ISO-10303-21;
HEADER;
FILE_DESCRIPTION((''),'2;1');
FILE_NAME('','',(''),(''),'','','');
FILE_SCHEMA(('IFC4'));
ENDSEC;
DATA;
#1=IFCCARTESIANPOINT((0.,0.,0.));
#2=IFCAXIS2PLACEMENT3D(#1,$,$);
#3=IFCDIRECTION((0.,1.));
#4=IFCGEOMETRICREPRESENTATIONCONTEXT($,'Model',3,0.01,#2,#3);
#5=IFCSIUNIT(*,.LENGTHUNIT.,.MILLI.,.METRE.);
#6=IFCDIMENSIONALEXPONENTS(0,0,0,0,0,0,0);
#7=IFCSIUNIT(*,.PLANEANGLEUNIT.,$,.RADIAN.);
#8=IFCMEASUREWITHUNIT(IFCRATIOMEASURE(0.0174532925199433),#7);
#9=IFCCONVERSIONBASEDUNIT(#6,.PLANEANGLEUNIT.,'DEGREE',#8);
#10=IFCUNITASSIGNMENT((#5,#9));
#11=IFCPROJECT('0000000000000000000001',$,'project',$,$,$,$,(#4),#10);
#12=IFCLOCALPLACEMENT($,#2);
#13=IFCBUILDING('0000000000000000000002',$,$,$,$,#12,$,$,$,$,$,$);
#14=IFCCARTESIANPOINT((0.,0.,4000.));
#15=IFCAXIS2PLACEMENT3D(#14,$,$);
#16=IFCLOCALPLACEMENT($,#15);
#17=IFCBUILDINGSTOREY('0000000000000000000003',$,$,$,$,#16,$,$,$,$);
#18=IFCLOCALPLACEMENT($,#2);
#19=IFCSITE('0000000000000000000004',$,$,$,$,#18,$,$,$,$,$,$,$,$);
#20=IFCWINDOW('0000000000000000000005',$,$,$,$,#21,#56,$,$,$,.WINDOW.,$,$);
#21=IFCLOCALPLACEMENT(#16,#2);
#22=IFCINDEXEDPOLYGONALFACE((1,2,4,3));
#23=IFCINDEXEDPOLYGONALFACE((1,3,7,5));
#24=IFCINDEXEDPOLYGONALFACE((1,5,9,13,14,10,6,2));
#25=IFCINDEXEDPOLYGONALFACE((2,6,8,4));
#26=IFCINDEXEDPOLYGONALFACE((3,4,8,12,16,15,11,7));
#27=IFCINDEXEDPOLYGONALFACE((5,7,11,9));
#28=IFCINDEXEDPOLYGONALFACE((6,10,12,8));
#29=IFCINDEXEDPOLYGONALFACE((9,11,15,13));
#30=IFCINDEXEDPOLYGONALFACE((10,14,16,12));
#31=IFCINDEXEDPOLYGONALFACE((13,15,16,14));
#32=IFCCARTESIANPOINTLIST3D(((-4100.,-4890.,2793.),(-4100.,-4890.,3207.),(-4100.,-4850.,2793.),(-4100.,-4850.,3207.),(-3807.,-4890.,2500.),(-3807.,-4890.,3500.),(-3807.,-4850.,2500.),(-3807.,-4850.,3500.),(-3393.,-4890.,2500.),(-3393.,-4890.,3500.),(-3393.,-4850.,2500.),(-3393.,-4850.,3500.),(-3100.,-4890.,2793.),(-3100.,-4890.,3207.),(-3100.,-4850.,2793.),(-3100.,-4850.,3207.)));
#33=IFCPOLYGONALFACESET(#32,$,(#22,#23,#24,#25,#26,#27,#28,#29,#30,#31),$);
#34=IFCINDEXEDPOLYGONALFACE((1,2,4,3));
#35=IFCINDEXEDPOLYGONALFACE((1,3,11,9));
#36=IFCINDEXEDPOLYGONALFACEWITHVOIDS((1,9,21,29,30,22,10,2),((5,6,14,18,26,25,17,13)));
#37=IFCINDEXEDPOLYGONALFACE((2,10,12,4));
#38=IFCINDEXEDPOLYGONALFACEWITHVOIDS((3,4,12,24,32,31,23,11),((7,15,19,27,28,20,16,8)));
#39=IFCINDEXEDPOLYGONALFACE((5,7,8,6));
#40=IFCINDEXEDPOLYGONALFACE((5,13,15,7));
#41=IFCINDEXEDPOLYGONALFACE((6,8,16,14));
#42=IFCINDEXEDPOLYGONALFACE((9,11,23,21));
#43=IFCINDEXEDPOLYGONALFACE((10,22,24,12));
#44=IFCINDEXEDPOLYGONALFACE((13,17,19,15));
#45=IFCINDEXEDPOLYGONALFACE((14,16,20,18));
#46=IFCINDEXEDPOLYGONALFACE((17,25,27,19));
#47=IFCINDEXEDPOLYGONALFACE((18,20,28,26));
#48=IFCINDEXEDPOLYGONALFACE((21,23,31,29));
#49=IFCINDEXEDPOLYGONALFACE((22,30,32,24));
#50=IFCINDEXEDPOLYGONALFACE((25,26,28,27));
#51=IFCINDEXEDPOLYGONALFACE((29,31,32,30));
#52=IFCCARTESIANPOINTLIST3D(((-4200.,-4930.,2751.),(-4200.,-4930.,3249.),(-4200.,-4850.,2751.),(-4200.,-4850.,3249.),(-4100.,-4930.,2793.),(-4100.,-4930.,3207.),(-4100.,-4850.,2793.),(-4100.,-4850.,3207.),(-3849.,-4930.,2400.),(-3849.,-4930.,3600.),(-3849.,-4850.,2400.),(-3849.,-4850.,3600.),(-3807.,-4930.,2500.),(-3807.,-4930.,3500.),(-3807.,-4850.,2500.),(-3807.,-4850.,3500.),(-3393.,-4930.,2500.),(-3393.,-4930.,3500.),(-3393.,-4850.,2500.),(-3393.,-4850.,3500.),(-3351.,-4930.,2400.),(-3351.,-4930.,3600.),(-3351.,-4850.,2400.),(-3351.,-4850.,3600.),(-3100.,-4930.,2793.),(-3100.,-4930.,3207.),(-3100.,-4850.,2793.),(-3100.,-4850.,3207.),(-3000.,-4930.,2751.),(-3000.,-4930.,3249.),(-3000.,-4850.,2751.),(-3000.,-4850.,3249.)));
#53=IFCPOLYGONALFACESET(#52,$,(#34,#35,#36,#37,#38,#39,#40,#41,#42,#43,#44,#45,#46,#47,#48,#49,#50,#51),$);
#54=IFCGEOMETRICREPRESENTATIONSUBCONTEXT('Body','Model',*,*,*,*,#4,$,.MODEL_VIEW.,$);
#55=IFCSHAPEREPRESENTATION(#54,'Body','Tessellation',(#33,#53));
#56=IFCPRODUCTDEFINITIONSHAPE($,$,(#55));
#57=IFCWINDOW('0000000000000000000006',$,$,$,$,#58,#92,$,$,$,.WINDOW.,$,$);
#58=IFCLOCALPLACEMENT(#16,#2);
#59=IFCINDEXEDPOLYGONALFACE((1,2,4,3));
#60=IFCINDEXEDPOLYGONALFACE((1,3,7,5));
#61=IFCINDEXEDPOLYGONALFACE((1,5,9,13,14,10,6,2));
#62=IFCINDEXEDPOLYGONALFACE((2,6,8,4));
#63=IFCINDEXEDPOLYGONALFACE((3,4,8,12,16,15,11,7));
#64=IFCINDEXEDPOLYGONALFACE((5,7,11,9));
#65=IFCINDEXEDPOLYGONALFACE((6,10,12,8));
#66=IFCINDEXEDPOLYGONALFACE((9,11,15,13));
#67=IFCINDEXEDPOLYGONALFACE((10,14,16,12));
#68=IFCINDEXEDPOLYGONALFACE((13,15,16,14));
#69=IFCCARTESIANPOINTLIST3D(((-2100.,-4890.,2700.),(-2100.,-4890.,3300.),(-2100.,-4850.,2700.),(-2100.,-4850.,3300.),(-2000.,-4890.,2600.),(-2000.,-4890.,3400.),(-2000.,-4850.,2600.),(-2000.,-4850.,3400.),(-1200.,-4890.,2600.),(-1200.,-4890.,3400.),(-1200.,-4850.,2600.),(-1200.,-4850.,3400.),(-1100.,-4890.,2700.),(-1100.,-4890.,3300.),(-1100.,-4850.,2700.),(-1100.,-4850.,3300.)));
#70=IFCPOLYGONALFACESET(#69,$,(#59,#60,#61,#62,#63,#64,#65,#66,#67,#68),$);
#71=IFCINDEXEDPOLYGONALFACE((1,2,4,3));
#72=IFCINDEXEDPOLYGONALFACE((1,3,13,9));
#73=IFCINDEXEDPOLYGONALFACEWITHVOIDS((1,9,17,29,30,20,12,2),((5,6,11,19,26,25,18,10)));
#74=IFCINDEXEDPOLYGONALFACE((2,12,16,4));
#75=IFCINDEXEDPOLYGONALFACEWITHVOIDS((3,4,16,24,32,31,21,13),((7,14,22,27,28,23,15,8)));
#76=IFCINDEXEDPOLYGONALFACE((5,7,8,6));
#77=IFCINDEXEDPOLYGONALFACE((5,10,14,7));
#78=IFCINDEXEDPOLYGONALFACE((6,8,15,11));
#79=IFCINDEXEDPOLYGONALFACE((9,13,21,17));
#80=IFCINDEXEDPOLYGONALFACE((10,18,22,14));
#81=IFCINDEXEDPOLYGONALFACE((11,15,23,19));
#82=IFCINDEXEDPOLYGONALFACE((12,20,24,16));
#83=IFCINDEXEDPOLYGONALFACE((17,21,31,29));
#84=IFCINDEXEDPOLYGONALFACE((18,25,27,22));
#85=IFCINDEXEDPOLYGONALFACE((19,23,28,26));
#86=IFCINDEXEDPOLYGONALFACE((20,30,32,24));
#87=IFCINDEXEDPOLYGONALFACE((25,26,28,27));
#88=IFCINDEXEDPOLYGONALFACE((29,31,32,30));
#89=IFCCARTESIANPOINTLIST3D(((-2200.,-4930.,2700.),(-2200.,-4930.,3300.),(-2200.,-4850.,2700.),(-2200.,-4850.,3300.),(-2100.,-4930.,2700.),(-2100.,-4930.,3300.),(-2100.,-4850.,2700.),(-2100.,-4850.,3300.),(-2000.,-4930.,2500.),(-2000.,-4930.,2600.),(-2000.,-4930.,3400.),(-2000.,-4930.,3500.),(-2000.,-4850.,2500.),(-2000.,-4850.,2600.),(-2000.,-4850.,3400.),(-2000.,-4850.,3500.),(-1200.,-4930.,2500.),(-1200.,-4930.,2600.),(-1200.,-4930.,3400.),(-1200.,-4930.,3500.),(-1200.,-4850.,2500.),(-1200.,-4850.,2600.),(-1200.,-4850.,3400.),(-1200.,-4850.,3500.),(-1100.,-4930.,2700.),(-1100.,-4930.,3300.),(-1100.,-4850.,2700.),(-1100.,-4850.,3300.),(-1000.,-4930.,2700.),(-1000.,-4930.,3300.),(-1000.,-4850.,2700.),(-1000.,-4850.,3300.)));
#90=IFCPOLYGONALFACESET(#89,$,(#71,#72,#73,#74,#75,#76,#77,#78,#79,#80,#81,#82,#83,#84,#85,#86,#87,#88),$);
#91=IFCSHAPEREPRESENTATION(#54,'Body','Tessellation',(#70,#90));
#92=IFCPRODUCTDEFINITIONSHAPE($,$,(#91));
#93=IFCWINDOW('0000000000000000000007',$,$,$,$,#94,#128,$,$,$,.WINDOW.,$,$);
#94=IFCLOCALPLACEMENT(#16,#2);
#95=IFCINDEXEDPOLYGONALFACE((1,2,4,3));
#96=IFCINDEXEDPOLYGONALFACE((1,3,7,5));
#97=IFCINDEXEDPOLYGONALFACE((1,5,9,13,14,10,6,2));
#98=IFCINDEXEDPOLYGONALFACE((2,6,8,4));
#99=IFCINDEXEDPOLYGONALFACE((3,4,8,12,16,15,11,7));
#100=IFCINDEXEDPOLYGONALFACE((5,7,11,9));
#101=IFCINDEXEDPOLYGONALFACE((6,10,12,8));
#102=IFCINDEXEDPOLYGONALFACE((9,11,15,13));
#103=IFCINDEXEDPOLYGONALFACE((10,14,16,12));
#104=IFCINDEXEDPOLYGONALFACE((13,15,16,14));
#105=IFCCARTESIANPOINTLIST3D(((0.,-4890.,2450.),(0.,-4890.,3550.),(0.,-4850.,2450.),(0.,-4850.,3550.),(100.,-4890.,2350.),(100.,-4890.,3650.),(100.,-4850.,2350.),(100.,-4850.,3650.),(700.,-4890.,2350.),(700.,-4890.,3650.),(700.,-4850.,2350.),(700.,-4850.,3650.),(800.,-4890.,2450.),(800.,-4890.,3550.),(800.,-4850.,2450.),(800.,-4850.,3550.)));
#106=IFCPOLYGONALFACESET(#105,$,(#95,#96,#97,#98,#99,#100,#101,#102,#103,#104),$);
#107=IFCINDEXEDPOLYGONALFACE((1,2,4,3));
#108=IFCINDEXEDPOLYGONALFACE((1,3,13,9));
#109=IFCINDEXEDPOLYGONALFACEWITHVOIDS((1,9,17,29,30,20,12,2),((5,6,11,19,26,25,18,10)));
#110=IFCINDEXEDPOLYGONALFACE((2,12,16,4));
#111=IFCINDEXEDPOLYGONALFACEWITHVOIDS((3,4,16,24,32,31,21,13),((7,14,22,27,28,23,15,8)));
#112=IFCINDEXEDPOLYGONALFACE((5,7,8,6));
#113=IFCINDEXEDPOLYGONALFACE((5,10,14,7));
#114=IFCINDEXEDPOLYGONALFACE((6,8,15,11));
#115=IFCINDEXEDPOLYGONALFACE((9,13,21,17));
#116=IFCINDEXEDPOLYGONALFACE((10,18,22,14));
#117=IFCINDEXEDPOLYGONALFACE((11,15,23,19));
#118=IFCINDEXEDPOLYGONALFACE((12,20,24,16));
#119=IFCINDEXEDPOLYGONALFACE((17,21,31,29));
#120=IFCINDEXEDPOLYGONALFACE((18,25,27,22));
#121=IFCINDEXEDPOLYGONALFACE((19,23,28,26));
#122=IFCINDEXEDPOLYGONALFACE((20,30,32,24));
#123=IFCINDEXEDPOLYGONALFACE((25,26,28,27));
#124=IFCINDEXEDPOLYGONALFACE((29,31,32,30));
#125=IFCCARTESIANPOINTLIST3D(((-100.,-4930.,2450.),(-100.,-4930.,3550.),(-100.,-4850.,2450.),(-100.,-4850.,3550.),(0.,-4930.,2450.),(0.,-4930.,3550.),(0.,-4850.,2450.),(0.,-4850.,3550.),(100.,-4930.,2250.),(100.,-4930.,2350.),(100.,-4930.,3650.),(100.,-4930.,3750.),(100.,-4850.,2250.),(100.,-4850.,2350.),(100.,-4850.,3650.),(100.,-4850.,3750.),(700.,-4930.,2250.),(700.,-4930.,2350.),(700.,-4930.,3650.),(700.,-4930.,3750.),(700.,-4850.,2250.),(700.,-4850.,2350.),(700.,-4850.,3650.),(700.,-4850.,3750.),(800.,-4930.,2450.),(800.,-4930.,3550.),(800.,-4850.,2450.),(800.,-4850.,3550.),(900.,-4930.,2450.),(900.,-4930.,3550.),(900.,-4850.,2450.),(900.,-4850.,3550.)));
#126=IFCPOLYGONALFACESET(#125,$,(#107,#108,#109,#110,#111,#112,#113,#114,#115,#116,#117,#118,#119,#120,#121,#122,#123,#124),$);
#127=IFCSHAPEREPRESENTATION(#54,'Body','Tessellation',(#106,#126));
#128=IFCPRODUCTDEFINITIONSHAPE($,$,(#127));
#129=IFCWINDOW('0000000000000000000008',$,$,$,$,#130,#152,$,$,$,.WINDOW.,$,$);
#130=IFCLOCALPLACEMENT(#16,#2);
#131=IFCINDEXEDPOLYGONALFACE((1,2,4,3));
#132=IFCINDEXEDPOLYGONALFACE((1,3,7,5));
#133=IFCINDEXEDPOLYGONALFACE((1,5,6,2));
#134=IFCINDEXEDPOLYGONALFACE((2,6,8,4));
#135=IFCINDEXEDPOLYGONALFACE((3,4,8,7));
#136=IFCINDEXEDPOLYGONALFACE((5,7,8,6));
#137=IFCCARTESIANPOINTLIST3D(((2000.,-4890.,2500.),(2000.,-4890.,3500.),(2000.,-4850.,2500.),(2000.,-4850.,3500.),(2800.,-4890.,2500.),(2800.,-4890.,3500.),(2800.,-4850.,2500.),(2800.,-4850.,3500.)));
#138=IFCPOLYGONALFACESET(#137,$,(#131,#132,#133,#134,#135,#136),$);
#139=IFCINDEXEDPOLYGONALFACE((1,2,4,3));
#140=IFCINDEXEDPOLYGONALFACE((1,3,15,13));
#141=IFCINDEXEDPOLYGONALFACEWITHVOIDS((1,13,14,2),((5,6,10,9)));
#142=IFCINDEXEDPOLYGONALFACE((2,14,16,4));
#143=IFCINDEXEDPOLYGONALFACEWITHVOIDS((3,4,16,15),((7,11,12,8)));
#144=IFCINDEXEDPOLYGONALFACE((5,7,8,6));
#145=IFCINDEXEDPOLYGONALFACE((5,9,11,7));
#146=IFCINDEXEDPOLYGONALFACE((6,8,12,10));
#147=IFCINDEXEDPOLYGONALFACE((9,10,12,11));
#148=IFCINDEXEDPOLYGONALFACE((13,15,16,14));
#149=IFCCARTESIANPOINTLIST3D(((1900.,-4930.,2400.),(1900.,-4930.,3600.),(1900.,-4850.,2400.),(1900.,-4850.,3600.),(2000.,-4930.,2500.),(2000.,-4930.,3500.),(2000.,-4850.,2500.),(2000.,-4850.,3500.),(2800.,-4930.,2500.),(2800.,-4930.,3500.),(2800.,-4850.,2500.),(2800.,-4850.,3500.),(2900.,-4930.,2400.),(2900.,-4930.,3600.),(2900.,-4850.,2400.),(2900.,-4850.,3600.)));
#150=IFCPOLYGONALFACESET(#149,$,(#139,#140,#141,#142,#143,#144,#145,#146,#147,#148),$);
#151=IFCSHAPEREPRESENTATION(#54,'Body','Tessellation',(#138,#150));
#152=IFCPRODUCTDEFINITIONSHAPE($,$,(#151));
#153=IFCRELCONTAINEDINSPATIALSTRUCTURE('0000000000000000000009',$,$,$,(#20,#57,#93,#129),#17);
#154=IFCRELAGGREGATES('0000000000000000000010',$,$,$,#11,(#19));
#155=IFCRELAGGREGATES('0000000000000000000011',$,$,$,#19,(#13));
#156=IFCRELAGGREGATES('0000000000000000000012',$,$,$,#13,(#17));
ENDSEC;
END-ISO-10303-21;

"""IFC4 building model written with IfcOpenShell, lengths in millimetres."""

from ifc_helpers import new_model, entity, si_unit, converted_unit, direction, frame, origin, place, context, subcontext, project, spatial, element, save


model = new_model("IFC4")

# Units and contexts
model_context = context("Model", 3, precision=0.01, world=origin(), true_north=direction((0.0, 1.0)))
body_context = subcontext(model_context, "Body", "Model", "MODEL_VIEW")
ifc_project = project(units=[si_unit("LENGTHUNIT", "METRE", prefix="MILLI"), converted_unit("PLANEANGLEUNIT", "DEGREE", entity("IfcRatioMeasure", 0.0174532925199433), si_unit("PLANEANGLEUNIT", "RADIAN"), dimensions=[0, 0, 0, 0, 0, 0, 0])], contexts=[model_context])

# Site, building, storey
site_placement = place(None, origin())
site = spatial("IfcSite", under=ifc_project, at=site_placement)
building_placement = place(None, origin())
building = spatial("IfcBuilding", under=site, at=building_placement)
storey_placement = place(None, frame((0.0, 0.0, 4000.0)))
storey = spatial("IfcBuildingStorey", under=building, at=storey_placement)

# Shared definitions
cartesian_point_1 = entity("IfcCartesianPoint", [-500.0, -207.0])
shared_polyline_1 = entity("IfcPolyline", [cartesian_point_1, entity("IfcCartesianPoint", [-500.0, 207.0]), entity("IfcCartesianPoint", [-207.0, 500.0]), entity("IfcCartesianPoint", [207.0, 500.0]), entity("IfcCartesianPoint", [500.0, 207.0]), entity("IfcCartesianPoint", [500.0, -207.0]), entity("IfcCartesianPoint", [207.0, -500.0]), entity("IfcCartesianPoint", [-207.0, -500.0]), cartesian_point_1])
cartesian_point_2 = entity("IfcCartesianPoint", [-500.0, -300.0])
shared_polyline_2 = entity("IfcPolyline", [cartesian_point_2, entity("IfcCartesianPoint", [-500.0, 300.0]), entity("IfcCartesianPoint", [-400.0, 400.0]), entity("IfcCartesianPoint", [400.0, 400.0]), entity("IfcCartesianPoint", [500.0, 300.0]), entity("IfcCartesianPoint", [500.0, -300.0]), entity("IfcCartesianPoint", [400.0, -400.0]), entity("IfcCartesianPoint", [-400.0, -400.0]), cartesian_point_2])
cartesian_point_3 = entity("IfcCartesianPoint", [-400.0, -550.0])
shared_polyline_3 = entity("IfcPolyline", [cartesian_point_3, entity("IfcCartesianPoint", [-400.0, 550.0]), entity("IfcCartesianPoint", [-300.0, 650.0]), entity("IfcCartesianPoint", [300.0, 650.0]), entity("IfcCartesianPoint", [400.0, 550.0]), entity("IfcCartesianPoint", [400.0, -550.0]), entity("IfcCartesianPoint", [300.0, -650.0]), entity("IfcCartesianPoint", [-300.0, -650.0]), cartesian_point_3])
cartesian_point_4 = entity("IfcCartesianPoint", [-400.0, -500.0])
shared_polyline_4 = entity("IfcPolyline", [cartesian_point_4, entity("IfcCartesianPoint", [-400.0, 500.0]), entity("IfcCartesianPoint", [-400.0, 500.0]), entity("IfcCartesianPoint", [400.0, 500.0]), entity("IfcCartesianPoint", [400.0, 500.0]), entity("IfcCartesianPoint", [400.0, -500.0]), entity("IfcCartesianPoint", [400.0, -500.0]), entity("IfcCartesianPoint", [-400.0, -500.0]), cartesian_point_4])

# Shared definitions
wall_1_placement = place(storey_placement, frame((-100.0, -4900.0, 0.0), z_axis=(0.0, 0.0, 1.0), x_axis=(1.0, 0.0, 0.0)))
window_1_placement = place(wall_1_placement, frame((-3500.0, 50.0, 3000.0)))
window_2_placement = place(wall_1_placement, frame((-1500.0, 50.0, 3000.0)))
window_3_placement = place(wall_1_placement, frame((500.0, 50.0, 3000.0)))
window_4_placement = place(wall_1_placement, frame((2500.0, 50.0, 3000.0)))

# Windows
cartesian_point_5 = entity("IfcCartesianPoint", [-600.0, -249.0])
element("IfcWindow", 1, at=window_1_placement, inside=storey, PredefinedType="WINDOW", context=body_context, shape_type="SweptSolid", body=[
    entity("IfcExtrudedAreaSolid", entity("IfcArbitraryClosedProfileDef", "AREA", None, shared_polyline_1), entity("IfcAxis2Placement3D", entity("IfcCartesianPoint", [0.0, 0.0, 0.0]), entity("IfcDirection", [0.0, -1.0, 0.0]), entity("IfcDirection", [1.0, 0.0, 0.0])), entity("IfcDirection", [0.0, 0.0, 1.0]), 40.0),
    entity("IfcExtrudedAreaSolid", entity("IfcArbitraryProfileDefWithVoids", "AREA", None, entity("IfcPolyline", [cartesian_point_5, entity("IfcCartesianPoint", [-600.0, 249.0]), entity("IfcCartesianPoint", [-249.0, 600.0]), entity("IfcCartesianPoint", [249.0, 600.0]), entity("IfcCartesianPoint", [600.0, 249.0]), entity("IfcCartesianPoint", [600.0, -249.0]), entity("IfcCartesianPoint", [249.0, -600.0]), entity("IfcCartesianPoint", [-249.0, -600.0]), cartesian_point_5]), [shared_polyline_1]), entity("IfcAxis2Placement3D", entity("IfcCartesianPoint", [0.0, 0.0, 0.0]), entity("IfcDirection", [0.0, -1.0, 0.0]), entity("IfcDirection", [1.0, 0.0, 0.0])), entity("IfcDirection", [0.0, 0.0, 1.0]), 80.0),
])
cartesian_point_6 = entity("IfcCartesianPoint", [-600.0, -300.0])
element("IfcWindow", 2, at=window_2_placement, inside=storey, PredefinedType="WINDOW", context=body_context, shape_type="SweptSolid", body=[
    entity("IfcExtrudedAreaSolid", entity("IfcArbitraryClosedProfileDef", "AREA", None, shared_polyline_2), entity("IfcAxis2Placement3D", entity("IfcCartesianPoint", [0.0, 0.0, 0.0]), entity("IfcDirection", [0.0, -1.0, 0.0]), entity("IfcDirection", [1.0, 0.0, 0.0])), entity("IfcDirection", [0.0, 0.0, 1.0]), 40.0),
    entity("IfcExtrudedAreaSolid", entity("IfcArbitraryProfileDefWithVoids", "AREA", None, entity("IfcPolyline", [cartesian_point_6, entity("IfcCartesianPoint", [-600.0, 300.0]), entity("IfcCartesianPoint", [-400.0, 500.0]), entity("IfcCartesianPoint", [400.0, 500.0]), entity("IfcCartesianPoint", [600.0, 300.0]), entity("IfcCartesianPoint", [600.0, -300.0]), entity("IfcCartesianPoint", [400.0, -500.0]), entity("IfcCartesianPoint", [-400.0, -500.0]), cartesian_point_6]), [shared_polyline_2]), entity("IfcAxis2Placement3D", entity("IfcCartesianPoint", [0.0, 0.0, 0.0]), entity("IfcDirection", [0.0, -1.0, 0.0]), entity("IfcDirection", [1.0, 0.0, 0.0])), entity("IfcDirection", [0.0, 0.0, 1.0]), 80.0),
])
cartesian_point_7 = entity("IfcCartesianPoint", [-500.0, -550.0])
element("IfcWindow", 3, at=window_3_placement, inside=storey, PredefinedType="WINDOW", context=body_context, shape_type="SweptSolid", body=[
    entity("IfcExtrudedAreaSolid", entity("IfcArbitraryClosedProfileDef", "AREA", None, shared_polyline_3), entity("IfcAxis2Placement3D", entity("IfcCartesianPoint", [0.0, 0.0, 0.0]), entity("IfcDirection", [0.0, -1.0, 0.0]), entity("IfcDirection", [1.0, 0.0, 0.0])), entity("IfcDirection", [0.0, 0.0, 1.0]), 40.0),
    entity("IfcExtrudedAreaSolid", entity("IfcArbitraryProfileDefWithVoids", "AREA", None, entity("IfcPolyline", [cartesian_point_7, entity("IfcCartesianPoint", [-500.0, 550.0]), entity("IfcCartesianPoint", [-300.0, 750.0]), entity("IfcCartesianPoint", [300.0, 750.0]), entity("IfcCartesianPoint", [500.0, 550.0]), entity("IfcCartesianPoint", [500.0, -550.0]), entity("IfcCartesianPoint", [300.0, -750.0]), entity("IfcCartesianPoint", [-300.0, -750.0]), cartesian_point_7]), [shared_polyline_3]), entity("IfcAxis2Placement3D", entity("IfcCartesianPoint", [0.0, 0.0, 0.0]), entity("IfcDirection", [0.0, -1.0, 0.0]), entity("IfcDirection", [1.0, 0.0, 0.0])), entity("IfcDirection", [0.0, 0.0, 1.0]), 80.0),
])
cartesian_point_8 = entity("IfcCartesianPoint", [-500.0, -600.0])
element("IfcWindow", 4, at=window_4_placement, inside=storey, PredefinedType="WINDOW", context=body_context, shape_type="SweptSolid", body=[
    entity("IfcExtrudedAreaSolid", entity("IfcArbitraryClosedProfileDef", "AREA", None, shared_polyline_4), entity("IfcAxis2Placement3D", entity("IfcCartesianPoint", [0.0, 0.0, 0.0]), entity("IfcDirection", [0.0, -1.0, 0.0]), entity("IfcDirection", [1.0, 0.0, 0.0])), entity("IfcDirection", [0.0, 0.0, 1.0]), 40.0),
    entity("IfcExtrudedAreaSolid", entity("IfcArbitraryProfileDefWithVoids", "AREA", None, entity("IfcPolyline", [cartesian_point_8, entity("IfcCartesianPoint", [-500.0, 600.0]), entity("IfcCartesianPoint", [-500.0, 600.0]), entity("IfcCartesianPoint", [500.0, 600.0]), entity("IfcCartesianPoint", [500.0, 600.0]), entity("IfcCartesianPoint", [500.0, -600.0]), entity("IfcCartesianPoint", [500.0, -600.0]), entity("IfcCartesianPoint", [-500.0, -600.0]), cartesian_point_8]), [shared_polyline_4]), entity("IfcAxis2Placement3D", entity("IfcCartesianPoint", [0.0, 0.0, 0.0]), entity("IfcDirection", [0.0, -1.0, 0.0]), entity("IfcDirection", [1.0, 0.0, 0.0])), entity("IfcDirection", [0.0, 0.0, 1.0]), 80.0),
])

save(model, "model.ifc")
